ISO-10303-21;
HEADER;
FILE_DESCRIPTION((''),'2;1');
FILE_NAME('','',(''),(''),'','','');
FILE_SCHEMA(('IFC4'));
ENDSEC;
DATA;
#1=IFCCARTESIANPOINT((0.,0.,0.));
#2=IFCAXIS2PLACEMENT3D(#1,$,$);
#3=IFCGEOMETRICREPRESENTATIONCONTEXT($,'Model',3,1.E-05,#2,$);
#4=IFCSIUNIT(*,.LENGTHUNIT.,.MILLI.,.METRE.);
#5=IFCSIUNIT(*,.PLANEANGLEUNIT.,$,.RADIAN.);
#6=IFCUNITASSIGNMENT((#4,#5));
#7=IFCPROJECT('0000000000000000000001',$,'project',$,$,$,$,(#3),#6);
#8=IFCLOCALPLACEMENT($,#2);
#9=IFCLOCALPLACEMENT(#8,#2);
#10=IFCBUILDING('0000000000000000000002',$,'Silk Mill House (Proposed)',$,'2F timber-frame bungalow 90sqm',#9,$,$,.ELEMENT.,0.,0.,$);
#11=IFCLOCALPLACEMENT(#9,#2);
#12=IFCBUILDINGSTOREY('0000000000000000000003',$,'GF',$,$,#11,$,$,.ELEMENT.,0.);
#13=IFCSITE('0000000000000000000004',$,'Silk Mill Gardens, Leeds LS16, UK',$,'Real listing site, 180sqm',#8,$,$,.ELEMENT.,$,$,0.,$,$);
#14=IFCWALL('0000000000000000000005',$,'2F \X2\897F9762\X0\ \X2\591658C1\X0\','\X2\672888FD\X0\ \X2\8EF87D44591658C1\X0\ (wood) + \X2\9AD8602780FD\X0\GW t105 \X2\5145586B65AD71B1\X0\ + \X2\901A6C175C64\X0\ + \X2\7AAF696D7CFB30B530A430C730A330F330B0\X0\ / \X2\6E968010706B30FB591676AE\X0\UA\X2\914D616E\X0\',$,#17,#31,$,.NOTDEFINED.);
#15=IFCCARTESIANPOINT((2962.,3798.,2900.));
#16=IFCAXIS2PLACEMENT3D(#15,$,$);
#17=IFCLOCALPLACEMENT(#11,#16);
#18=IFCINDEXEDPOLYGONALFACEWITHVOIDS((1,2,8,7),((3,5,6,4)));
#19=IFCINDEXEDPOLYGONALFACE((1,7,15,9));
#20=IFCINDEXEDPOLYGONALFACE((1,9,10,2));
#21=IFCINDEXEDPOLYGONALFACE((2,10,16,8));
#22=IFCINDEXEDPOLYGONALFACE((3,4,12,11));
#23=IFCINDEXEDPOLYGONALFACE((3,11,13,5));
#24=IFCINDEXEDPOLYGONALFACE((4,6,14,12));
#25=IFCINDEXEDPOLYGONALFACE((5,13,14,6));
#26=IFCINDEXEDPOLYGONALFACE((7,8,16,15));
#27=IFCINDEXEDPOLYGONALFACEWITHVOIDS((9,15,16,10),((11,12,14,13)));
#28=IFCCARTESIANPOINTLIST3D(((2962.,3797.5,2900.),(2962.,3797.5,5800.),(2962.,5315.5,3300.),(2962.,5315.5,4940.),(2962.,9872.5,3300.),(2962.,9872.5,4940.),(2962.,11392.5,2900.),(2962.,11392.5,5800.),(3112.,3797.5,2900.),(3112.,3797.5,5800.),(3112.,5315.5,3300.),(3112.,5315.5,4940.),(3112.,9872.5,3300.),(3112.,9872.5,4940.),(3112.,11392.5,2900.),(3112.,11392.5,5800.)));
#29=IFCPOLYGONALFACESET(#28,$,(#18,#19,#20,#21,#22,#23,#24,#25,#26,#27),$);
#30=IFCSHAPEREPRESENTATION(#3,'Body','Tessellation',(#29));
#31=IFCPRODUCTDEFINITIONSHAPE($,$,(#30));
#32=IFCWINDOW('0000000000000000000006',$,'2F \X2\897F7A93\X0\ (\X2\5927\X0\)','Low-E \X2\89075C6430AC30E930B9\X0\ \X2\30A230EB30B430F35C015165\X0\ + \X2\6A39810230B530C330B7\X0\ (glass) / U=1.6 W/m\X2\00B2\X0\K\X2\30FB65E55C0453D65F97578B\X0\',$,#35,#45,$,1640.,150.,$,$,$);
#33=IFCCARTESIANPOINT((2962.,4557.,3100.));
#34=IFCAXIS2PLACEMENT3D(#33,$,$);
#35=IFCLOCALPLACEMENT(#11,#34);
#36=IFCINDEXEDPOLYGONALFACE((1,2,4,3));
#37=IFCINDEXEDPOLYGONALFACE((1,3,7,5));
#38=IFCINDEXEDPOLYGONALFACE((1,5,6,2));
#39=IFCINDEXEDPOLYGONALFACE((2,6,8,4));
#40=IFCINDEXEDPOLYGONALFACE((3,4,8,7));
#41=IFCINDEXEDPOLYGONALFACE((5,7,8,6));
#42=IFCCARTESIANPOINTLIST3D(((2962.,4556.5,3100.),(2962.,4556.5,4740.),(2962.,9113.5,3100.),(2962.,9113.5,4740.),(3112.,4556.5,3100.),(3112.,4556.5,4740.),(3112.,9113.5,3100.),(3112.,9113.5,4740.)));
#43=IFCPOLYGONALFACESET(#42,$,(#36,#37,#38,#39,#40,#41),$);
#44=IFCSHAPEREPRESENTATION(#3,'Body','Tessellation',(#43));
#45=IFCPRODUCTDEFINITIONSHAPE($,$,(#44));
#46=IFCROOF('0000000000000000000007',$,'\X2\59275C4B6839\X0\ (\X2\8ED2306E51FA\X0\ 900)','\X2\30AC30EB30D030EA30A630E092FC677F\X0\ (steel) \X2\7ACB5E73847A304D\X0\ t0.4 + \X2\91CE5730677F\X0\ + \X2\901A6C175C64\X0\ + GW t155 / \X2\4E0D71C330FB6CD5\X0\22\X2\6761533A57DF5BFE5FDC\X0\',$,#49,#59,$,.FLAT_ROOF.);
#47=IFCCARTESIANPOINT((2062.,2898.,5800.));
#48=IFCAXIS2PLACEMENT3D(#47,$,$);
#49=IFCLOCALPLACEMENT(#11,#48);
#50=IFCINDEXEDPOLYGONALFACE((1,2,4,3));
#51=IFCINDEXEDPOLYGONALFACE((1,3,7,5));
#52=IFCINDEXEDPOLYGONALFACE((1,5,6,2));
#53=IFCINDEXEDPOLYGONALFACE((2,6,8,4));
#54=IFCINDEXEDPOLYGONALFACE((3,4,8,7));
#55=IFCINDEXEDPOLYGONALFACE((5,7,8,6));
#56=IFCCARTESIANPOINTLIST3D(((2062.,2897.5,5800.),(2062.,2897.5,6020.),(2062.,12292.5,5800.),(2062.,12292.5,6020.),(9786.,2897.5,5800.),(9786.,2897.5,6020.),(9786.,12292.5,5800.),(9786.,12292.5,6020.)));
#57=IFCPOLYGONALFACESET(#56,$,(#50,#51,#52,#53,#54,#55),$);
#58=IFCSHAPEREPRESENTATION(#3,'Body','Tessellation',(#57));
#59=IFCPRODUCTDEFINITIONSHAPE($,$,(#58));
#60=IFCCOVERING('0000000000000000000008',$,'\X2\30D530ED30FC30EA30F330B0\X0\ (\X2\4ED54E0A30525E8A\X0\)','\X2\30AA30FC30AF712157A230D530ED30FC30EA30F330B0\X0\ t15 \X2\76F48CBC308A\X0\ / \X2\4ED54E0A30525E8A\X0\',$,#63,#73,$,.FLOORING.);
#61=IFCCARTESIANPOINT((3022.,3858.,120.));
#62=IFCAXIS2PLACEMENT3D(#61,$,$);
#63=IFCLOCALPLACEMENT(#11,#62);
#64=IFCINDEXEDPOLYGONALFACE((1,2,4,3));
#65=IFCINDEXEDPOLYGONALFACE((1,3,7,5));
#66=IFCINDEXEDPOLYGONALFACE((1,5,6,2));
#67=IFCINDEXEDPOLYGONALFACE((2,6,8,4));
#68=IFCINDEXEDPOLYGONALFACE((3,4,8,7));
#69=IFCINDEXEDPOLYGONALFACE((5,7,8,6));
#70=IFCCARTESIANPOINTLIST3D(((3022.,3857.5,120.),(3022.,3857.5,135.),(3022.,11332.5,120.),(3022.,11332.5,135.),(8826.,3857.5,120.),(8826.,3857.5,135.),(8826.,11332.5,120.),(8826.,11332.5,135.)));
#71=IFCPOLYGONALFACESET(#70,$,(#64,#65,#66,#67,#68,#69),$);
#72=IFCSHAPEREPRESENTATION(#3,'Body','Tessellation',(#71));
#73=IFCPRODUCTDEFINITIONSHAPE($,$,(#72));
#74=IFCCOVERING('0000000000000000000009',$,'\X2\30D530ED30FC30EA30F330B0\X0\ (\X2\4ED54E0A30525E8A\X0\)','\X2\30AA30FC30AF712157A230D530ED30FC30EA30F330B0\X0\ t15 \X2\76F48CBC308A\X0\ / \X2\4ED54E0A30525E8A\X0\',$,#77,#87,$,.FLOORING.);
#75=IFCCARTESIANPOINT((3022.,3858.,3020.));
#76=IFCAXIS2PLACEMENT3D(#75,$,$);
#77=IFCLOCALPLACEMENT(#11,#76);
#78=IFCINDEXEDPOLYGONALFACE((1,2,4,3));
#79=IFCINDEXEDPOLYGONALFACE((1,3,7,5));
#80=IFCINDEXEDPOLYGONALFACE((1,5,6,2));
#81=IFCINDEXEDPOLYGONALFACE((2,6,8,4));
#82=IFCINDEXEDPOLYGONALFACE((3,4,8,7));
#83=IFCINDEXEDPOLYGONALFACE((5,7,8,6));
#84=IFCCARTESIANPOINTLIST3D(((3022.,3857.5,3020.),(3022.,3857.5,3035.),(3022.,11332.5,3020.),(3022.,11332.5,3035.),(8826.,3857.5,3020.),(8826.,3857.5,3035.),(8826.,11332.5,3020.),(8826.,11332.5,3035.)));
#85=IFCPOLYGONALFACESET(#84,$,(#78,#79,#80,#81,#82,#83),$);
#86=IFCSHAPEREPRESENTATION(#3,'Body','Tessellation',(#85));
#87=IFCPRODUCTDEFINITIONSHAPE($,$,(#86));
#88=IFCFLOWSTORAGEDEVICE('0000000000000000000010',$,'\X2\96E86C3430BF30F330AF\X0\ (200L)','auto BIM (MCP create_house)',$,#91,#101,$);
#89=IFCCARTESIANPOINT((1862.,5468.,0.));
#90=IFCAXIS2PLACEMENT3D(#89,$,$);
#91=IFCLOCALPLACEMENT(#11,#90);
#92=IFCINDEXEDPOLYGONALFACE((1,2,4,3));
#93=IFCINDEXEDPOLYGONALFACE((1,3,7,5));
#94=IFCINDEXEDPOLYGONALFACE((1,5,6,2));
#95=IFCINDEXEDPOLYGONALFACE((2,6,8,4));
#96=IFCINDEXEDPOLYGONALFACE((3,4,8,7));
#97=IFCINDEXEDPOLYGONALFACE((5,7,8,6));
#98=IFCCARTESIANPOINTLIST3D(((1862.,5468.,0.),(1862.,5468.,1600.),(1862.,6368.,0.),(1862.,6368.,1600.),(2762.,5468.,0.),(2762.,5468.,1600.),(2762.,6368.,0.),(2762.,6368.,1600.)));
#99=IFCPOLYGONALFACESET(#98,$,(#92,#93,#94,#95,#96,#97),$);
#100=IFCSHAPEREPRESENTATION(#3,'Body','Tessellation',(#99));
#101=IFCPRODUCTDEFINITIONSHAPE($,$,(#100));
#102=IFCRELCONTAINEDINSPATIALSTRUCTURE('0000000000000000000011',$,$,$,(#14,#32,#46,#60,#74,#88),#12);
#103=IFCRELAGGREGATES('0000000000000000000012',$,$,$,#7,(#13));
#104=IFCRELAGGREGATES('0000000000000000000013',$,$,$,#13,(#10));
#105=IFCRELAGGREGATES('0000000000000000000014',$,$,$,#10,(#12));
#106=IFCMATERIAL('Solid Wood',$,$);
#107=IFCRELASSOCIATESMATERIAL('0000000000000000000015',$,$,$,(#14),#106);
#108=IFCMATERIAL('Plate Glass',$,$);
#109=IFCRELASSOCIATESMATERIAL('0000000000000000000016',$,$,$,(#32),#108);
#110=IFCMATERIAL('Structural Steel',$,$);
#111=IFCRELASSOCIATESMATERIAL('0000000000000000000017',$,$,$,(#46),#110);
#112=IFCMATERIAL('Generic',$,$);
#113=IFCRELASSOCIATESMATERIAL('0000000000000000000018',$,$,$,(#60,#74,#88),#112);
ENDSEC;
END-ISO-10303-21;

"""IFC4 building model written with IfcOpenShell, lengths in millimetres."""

from ifc_helpers import new_model, si_unit, frame, frame_2d, origin, place, context, project, spatial, rectangle, extrude, material, element, fill, save


model = new_model("IFC4")

# Units and contexts
model_context = context("Model", 3, precision=1e-05, world=origin())
ifc_project = project(units=[si_unit("LENGTHUNIT", "METRE", prefix="MILLI"), si_unit("PLANEANGLEUNIT", "RADIAN")], contexts=[model_context])

# Site, building, storey
site_placement = place(None, origin())
site = spatial("IfcSite", under=ifc_project, at=site_placement, Name="Silk Mill Gardens, Leeds LS16, UK", ObjectType="Real listing site, 180sqm", CompositionType="ELEMENT", RefElevation=0.0)
building_placement = place(site_placement, origin())
building = spatial("IfcBuilding", under=site, at=building_placement, Name="Silk Mill House (Proposed)", ObjectType="2F timber-frame bungalow 90sqm", CompositionType="ELEMENT", ElevationOfRefHeight=0.0, ElevationOfTerrain=0.0)
storey_placement = place(building_placement, origin())
storey = spatial("IfcBuildingStorey", under=building, at=storey_placement, Name="GF", CompositionType="ELEMENT", Elevation=0.0)

# Shared definitions
ifc_material_1 = material(Name="Solid Wood")

# Shared definitions
ifc_material_2 = material(Name="Plate Glass")

# Wall, opening, window
wall_1_placement = place(storey_placement, frame((2962.0, 3798.0, 2900.0)))
wall_1 = element("IfcWall", 1, at=wall_1_placement, inside=storey, material=ifc_material_1, Name="2F 西面 外壁", Description="木製 軸組外壁 (wood) + 高性能GW t105 充填断熱 + 通気層 + 窯業系サイディング / 準耐火・外皮UA配慮", PredefinedType="NOTDEFINED", context=model_context, shape_type="SweptSolid", body=[
    extrude(rectangle(XDim=150.0, YDim=7595.0, at=frame_2d((75.0, 3797.0))), frame((2962.0, 3798.0, 2900.0)), (0.0, 0.0, 1.0), 2900.0),
])
opening_1_placement = place(storey_placement, frame((2962.0, 4557.0, 3100.0)))
opening_1 = element("IfcOpeningElement", 2, at=opening_1_placement, cuts=wall_1, PredefinedType="NOTDEFINED", context=model_context, shape_type="SweptSolid", body=[
    extrude(rectangle(XDim=150.0, YDim=4557.0, at=frame_2d((75.0, 2278.0))), frame((2962.0, 4557.0, 3100.0)), (0.0, 0.0, 1.0), 1640.0),
])
window_1_placement = place(storey_placement, frame((2962.0, 4557.0, 3100.0)))
window_1 = element("IfcWindow", 3, at=window_1_placement, inside=storey, material=ifc_material_2, Name="2F 西窓 (大)", Description="Low-E 複層ガラス アルゴン封入 + 樹脂サッシ (glass) / U=1.6 W/m²K・日射取得型", OverallHeight=1640.0, OverallWidth=150.0, context=model_context, shape_type="SweptSolid", body=[
    extrude(rectangle(XDim=150.0, YDim=4557.0, at=frame_2d((75.0, 2278.0))), frame((2962.0, 4557.0, 3100.0)), (0.0, 0.0, 1.0), 1640.0),
])
fill(opening_1, window_1)

# Roof
ifc_material_3 = material(Name="Structural Steel")
roof_placement = place(storey_placement, frame((2062.0, 2898.0, 5800.0)))
element("IfcRoof", 4, at=roof_placement, inside=storey, material=ifc_material_3, Name="大屋根 (軒の出 900)", Description="ガルバリウム鋼板 (steel) 立平葺き t0.4 + 野地板 + 通気層 + GW t155 / 不燃・法22条区域対応", PredefinedType="FLAT_ROOF", context=model_context, shape_type="SweptSolid", body=[
    extrude(rectangle(XDim=7724.0, YDim=9395.0, at=frame_2d((3862.0, 4697.0))), frame((2062.0, 2898.0, 5800.0)), (0.0, 0.0, 1.0), 220.0),
])

# Coverings
ifc_material_4 = material(Name="Generic")
covering_1_placement = place(storey_placement, frame((3022.0, 3858.0, 120.0)))
element("IfcCovering", 5, at=covering_1_placement, inside=storey, material=ifc_material_4, Name="フローリング (仕上げ床)", Description="オーク無垢フローリング t15 直貼り / 仕上げ床", PredefinedType="FLOORING", context=model_context, shape_type="SweptSolid", body=[
    extrude(rectangle(XDim=5804.0, YDim=7475.0, at=frame_2d((2902.0, 3737.0))), frame((3022.0, 3858.0, 120.0)), (0.0, 0.0, 1.0), 15.0),
])
covering_2_placement = place(storey_placement, frame((3022.0, 3858.0, 3020.0)))
element("IfcCovering", 6, at=covering_2_placement, inside=storey, material=ifc_material_4, Name="フローリング (仕上げ床)", Description="オーク無垢フローリング t15 直貼り / 仕上げ床", PredefinedType="FLOORING", context=model_context, shape_type="SweptSolid", body=[
    extrude(rectangle(XDim=5804.0, YDim=7475.0, at=frame_2d((2902.0, 3737.0))), frame((3022.0, 3858.0, 3020.0)), (0.0, 0.0, 1.0), 15.0),
])

# Flow storage device
flow_storage_device_placement = place(storey_placement, frame((1862.0, 5468.0, 0.0)))
element("IfcFlowStorageDevice", 7, at=flow_storage_device_placement, inside=storey, material=ifc_material_4, Name="雨水タンク (200L)", Description="auto BIM (MCP create_house)", context=model_context, shape_type="SweptSolid", body=[
    extrude(rectangle(XDim=900.0, YDim=900.0, at=frame_2d((450.0, 450.0))), frame((1862.0, 5468.0, 0.0)), (0.0, 0.0, 1.0), 1600.0),
])

save(model, "model.ifc")
